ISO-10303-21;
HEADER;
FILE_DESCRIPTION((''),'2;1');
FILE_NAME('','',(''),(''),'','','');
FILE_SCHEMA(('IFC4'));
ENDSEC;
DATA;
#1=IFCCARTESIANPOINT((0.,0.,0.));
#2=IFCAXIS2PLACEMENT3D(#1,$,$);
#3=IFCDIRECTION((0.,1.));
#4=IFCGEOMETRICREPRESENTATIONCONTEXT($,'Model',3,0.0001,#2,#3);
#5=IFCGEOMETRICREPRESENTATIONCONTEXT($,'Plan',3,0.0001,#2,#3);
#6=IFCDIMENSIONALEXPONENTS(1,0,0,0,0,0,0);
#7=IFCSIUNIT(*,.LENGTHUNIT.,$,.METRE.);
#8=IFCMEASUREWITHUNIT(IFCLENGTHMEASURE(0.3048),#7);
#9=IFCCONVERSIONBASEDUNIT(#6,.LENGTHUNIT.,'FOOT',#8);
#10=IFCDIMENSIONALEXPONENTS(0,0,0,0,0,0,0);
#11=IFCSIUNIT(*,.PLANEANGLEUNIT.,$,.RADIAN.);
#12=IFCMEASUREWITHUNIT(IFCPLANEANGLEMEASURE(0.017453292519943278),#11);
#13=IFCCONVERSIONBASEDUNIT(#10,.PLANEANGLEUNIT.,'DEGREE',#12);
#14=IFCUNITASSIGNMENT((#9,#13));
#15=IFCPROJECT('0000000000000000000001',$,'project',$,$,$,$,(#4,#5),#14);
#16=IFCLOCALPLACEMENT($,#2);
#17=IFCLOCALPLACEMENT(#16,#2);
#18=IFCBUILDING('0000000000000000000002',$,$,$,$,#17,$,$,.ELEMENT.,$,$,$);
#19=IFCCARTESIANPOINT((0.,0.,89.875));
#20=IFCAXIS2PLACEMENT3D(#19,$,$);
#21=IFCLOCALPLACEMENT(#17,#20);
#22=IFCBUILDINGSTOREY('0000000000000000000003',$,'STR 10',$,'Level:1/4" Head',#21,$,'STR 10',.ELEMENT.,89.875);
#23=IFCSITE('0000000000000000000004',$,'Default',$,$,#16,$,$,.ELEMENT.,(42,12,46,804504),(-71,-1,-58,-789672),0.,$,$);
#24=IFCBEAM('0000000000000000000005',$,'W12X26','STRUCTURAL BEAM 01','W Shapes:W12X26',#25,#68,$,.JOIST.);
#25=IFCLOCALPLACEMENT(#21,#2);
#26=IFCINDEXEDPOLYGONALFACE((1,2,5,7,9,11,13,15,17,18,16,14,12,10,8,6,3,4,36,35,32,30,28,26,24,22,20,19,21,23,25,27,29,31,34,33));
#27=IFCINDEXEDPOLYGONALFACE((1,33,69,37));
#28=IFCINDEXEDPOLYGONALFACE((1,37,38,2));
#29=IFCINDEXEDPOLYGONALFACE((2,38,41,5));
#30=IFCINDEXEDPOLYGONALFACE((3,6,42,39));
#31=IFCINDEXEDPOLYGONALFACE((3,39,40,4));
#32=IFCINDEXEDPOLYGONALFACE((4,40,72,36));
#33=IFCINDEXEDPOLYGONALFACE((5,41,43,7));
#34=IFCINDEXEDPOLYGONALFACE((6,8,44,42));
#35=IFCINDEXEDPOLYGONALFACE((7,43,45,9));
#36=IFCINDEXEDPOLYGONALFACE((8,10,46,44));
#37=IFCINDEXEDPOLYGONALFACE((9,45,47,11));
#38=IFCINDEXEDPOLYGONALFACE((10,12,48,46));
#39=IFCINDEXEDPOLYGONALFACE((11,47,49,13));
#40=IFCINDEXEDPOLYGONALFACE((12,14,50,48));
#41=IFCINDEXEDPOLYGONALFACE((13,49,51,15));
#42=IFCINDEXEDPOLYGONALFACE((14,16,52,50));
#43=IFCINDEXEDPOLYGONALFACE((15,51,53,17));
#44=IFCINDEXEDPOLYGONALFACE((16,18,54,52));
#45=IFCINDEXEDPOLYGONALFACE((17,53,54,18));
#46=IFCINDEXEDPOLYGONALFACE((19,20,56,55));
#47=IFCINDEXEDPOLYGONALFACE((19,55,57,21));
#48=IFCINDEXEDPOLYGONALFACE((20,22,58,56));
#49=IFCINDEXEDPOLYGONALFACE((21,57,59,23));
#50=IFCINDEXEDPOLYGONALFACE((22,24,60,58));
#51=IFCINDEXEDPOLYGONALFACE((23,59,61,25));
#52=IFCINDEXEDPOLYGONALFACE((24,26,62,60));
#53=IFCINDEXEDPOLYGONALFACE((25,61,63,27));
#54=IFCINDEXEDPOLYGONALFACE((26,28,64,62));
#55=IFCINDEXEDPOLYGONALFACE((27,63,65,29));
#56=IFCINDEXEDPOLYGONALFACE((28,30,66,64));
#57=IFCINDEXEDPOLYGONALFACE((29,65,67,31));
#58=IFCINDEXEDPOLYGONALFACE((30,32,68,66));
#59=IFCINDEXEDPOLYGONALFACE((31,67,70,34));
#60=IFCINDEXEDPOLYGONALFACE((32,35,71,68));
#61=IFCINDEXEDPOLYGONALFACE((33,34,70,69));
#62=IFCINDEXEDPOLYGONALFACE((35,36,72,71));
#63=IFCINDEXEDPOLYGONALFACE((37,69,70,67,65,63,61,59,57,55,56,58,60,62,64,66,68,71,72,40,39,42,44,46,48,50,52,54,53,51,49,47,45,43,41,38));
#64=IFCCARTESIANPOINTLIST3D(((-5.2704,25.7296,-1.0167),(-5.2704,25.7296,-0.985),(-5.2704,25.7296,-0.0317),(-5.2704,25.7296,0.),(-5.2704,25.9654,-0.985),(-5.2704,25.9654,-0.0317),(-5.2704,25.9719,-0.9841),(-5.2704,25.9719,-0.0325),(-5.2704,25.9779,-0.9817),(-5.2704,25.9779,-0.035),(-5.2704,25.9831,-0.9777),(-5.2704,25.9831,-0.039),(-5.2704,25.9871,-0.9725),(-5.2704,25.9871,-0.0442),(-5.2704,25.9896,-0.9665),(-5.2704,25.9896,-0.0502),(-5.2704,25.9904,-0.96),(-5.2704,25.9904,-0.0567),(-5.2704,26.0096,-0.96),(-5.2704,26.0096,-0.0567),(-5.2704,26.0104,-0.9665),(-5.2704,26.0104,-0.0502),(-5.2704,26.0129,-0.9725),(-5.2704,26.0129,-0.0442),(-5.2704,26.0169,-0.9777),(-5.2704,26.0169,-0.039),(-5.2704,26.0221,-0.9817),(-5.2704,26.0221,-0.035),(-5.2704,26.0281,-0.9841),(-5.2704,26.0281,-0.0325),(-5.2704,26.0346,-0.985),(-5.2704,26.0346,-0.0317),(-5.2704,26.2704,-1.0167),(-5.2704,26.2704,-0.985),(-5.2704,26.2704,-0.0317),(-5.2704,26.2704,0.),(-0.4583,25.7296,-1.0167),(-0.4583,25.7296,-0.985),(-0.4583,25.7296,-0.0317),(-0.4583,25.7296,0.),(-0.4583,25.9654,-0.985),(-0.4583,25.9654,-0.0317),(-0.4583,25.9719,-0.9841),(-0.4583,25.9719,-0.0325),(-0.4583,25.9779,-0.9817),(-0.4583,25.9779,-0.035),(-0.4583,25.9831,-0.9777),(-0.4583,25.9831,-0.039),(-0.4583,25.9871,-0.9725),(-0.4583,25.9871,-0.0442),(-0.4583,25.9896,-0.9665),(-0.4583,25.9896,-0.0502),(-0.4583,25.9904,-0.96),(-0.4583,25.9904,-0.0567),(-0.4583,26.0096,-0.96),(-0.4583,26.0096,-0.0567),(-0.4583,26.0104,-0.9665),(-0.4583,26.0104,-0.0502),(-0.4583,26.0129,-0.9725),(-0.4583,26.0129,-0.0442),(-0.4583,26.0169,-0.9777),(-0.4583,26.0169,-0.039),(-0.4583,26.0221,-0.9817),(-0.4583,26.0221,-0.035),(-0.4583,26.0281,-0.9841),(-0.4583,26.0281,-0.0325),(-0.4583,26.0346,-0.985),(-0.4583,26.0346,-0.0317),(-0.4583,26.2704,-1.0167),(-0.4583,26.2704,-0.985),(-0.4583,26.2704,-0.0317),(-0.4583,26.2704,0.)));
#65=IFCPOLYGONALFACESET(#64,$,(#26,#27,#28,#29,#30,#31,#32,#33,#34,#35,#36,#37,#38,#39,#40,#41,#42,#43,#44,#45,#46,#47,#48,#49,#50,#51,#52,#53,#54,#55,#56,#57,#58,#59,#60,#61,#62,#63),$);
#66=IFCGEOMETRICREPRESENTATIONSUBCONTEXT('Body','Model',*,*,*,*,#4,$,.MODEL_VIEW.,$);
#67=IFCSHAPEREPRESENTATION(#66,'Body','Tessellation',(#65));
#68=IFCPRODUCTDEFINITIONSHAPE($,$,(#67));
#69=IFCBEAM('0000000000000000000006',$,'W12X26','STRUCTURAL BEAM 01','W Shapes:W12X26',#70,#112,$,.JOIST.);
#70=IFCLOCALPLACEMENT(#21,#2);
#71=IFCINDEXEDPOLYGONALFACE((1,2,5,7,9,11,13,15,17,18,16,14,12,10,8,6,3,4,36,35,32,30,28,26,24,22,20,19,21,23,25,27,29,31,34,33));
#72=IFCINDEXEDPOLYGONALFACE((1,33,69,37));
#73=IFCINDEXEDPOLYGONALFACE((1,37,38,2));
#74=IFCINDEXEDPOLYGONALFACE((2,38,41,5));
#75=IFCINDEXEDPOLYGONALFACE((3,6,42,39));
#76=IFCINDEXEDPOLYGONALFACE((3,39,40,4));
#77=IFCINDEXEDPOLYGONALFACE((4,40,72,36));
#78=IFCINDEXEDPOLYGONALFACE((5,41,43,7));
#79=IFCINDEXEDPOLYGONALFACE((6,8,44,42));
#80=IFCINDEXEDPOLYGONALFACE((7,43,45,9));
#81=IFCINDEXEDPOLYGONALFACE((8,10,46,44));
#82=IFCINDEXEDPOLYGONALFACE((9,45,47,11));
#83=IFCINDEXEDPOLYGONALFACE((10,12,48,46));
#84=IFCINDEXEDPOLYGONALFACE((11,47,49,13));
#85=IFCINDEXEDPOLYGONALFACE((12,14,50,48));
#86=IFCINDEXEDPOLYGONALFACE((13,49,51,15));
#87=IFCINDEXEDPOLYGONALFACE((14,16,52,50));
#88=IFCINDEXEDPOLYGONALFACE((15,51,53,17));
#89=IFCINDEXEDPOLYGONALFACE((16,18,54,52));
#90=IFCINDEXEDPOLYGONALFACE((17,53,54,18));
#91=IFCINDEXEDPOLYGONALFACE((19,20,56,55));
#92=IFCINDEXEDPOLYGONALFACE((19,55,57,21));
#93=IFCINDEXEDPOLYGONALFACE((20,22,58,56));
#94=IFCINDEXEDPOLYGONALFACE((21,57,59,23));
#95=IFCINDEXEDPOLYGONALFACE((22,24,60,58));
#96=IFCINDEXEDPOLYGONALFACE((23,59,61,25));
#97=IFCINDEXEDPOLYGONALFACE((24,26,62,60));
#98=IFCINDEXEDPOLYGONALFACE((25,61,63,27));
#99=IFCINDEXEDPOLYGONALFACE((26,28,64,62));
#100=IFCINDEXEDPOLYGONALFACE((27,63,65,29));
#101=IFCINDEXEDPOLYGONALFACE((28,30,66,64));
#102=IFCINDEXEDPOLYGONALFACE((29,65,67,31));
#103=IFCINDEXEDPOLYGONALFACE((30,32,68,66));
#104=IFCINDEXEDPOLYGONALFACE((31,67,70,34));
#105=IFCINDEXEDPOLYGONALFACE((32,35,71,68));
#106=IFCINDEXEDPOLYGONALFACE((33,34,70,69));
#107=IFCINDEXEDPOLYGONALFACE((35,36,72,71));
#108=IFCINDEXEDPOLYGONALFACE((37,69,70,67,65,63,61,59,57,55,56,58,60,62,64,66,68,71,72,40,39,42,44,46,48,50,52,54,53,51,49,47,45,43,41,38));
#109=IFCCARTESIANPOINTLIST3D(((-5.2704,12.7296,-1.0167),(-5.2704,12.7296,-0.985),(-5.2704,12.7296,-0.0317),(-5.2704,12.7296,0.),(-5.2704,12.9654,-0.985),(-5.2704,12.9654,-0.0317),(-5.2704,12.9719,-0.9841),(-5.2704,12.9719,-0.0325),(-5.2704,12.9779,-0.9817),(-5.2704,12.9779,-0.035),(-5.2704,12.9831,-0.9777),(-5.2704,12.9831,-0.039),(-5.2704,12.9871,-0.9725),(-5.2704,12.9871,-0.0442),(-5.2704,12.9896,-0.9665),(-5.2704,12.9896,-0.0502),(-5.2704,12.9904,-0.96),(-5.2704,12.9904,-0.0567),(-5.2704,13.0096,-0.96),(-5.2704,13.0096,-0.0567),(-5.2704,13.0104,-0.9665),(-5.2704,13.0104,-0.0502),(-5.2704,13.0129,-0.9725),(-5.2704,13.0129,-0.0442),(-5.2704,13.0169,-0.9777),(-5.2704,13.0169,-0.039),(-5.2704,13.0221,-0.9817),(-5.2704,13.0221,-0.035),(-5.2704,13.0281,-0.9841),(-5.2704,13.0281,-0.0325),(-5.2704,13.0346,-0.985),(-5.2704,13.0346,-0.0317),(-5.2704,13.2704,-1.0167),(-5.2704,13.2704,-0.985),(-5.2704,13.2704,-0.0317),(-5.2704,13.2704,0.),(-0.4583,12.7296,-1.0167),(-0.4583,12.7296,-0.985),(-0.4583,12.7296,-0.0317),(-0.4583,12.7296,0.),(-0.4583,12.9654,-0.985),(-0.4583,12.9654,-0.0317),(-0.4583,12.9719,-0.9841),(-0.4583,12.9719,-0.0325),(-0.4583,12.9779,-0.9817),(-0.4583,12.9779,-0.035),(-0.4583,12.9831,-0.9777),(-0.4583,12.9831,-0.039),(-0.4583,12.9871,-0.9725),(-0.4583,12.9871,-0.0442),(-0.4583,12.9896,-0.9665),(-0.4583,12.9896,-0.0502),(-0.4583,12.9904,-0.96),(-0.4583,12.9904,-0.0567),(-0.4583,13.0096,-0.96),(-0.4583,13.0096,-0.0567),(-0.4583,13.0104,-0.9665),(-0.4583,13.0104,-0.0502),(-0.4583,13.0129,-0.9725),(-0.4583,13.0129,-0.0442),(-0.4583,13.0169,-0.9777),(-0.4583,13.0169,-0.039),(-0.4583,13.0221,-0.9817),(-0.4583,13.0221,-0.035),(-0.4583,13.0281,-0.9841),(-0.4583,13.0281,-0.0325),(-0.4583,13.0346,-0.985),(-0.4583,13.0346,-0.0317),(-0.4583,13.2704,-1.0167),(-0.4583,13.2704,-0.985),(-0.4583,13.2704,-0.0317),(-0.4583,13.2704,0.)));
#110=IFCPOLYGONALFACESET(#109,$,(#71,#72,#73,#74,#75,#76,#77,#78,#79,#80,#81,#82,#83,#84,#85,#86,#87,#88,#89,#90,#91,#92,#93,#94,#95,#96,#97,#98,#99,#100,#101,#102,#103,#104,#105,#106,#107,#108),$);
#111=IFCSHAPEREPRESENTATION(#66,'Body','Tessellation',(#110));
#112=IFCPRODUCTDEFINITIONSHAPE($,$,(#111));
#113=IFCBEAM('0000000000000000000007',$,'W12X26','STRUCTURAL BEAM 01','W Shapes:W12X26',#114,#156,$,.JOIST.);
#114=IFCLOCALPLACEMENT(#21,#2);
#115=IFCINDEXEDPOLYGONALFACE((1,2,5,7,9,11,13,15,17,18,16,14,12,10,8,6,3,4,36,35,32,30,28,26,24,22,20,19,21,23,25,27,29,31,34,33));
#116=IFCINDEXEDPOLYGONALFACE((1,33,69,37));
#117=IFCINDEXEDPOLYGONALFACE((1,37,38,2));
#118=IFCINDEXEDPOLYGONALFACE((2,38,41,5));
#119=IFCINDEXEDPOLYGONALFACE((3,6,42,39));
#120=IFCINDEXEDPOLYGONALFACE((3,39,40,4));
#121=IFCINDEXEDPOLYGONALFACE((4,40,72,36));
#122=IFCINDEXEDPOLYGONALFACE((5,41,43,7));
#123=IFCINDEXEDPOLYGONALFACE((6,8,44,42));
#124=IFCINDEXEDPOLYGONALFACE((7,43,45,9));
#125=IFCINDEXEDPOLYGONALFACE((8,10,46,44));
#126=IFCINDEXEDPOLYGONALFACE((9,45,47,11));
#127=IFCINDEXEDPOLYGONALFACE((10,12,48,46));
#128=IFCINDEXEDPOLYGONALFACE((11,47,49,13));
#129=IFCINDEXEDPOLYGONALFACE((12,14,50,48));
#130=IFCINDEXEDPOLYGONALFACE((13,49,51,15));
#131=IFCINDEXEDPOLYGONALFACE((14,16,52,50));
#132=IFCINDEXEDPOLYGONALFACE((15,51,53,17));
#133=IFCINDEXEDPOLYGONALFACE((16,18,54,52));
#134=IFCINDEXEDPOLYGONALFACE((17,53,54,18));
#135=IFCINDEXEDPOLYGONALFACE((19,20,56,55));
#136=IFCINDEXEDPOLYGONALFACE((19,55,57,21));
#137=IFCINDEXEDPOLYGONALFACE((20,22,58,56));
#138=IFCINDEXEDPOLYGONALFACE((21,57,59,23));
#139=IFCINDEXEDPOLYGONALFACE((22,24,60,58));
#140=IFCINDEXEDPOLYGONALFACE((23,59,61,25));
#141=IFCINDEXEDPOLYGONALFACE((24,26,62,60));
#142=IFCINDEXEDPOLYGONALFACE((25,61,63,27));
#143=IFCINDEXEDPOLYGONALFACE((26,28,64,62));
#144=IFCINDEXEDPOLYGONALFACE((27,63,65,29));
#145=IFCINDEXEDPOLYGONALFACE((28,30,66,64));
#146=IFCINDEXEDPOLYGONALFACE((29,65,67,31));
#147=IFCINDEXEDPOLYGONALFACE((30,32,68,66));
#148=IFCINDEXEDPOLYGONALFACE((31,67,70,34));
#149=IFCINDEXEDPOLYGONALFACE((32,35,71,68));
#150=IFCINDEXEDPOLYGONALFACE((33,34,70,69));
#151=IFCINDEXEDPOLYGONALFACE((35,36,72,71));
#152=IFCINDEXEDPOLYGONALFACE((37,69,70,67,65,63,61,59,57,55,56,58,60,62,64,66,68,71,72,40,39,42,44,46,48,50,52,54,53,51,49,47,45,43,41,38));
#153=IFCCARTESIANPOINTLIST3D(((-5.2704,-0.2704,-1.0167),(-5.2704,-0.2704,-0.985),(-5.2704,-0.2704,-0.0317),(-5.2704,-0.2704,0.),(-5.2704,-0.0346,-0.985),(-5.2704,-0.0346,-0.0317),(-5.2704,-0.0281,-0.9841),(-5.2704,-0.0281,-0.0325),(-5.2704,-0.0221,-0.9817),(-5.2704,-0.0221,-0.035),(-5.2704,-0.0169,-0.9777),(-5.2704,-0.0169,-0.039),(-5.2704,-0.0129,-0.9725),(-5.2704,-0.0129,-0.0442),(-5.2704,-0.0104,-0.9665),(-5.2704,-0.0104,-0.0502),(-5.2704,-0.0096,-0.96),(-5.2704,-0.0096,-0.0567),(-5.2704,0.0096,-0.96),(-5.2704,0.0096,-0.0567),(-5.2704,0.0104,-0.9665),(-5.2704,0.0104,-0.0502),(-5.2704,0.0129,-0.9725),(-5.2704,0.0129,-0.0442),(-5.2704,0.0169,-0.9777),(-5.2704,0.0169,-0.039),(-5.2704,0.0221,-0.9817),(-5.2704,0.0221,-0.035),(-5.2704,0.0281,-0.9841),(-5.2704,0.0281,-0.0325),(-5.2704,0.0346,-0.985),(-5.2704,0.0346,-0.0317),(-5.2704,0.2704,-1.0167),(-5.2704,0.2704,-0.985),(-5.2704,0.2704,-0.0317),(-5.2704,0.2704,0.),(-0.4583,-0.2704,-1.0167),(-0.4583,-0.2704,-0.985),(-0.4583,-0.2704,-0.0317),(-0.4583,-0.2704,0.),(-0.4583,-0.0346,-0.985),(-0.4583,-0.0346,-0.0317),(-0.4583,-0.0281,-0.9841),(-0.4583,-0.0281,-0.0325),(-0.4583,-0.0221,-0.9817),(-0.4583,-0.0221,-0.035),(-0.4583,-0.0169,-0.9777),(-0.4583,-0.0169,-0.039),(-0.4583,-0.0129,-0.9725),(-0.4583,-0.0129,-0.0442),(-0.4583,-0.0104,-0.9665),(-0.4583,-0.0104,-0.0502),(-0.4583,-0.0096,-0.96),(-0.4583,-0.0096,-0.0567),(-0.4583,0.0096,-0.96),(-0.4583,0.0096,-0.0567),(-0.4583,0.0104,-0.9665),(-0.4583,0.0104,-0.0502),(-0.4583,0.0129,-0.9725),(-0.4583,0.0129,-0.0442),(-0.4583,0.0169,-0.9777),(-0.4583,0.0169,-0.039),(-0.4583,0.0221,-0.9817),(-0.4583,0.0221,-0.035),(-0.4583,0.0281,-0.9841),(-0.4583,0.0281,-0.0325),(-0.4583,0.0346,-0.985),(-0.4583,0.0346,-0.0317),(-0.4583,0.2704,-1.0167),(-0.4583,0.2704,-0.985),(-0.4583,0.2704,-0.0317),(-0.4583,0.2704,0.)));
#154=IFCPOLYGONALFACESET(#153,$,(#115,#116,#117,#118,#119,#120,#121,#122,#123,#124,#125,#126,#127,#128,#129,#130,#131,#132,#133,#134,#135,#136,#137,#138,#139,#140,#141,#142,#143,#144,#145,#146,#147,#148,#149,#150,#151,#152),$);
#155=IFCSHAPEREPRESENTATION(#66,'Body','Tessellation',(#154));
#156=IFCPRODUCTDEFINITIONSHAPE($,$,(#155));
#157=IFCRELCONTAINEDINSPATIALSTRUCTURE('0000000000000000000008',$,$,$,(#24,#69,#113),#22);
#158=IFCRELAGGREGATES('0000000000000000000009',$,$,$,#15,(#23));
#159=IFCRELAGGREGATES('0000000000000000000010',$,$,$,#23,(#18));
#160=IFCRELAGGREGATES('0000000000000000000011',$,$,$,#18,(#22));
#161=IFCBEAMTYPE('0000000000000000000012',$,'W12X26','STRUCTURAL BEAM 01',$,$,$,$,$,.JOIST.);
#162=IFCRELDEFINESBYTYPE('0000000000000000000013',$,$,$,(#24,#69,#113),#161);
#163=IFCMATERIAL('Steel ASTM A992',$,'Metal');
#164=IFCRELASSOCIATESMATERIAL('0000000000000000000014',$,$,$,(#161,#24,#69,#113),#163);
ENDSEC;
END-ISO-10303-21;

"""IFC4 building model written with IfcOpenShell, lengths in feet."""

from ifc_helpers import new_model, entity, si_unit, converted_unit, direction, frame, origin, place, context, subcontext, project, spatial, line, arc, indexed_curve, outline, extrude, source, transform, mapped, material, type_object, type_shapes, element, save


model = new_model("IFC4")

# Units and contexts
model_context = context("Model", 3, precision=0.0001, world=origin(), true_north=direction((0.0, 1.0)))
plan_context = context("Plan", 3, precision=0.0001, world=origin(), true_north=direction((0.0, 1.0)))
body_context = subcontext(model_context, "Body", "Model", "MODEL_VIEW")
ifc_project = project(units=[converted_unit("LENGTHUNIT", "FOOT", entity("IfcLengthMeasure", 0.3048), si_unit("LENGTHUNIT", "METRE"), dimensions=[1, 0, 0, 0, 0, 0, 0]), converted_unit("PLANEANGLEUNIT", "DEGREE", entity("IfcPlaneAngleMeasure", 0.017453292519943278), si_unit("PLANEANGLEUNIT", "RADIAN"), dimensions=[0, 0, 0, 0, 0, 0, 0])], contexts=[model_context, plan_context])

# Site, building, storey
site_placement = place(None, origin())
site = spatial("IfcSite", under=ifc_project, at=site_placement, Name="Default", CompositionType="ELEMENT", RefLatitude=(42, 12, 46, 804504), RefLongitude=(-71, -1, -58, -789672), RefElevation=0.0)
building_placement = place(site_placement, origin())
building = spatial("IfcBuilding", under=site, at=building_placement, CompositionType="ELEMENT")
storey_placement = place(building_placement, frame((0.0, 0.0, 89.875)))
storey = spatial("IfcBuildingStorey", under=building, at=storey_placement, Name="STR 10", ObjectType="Level:1/4\" Head", LongName="STR 10", CompositionType="ELEMENT", Elevation=89.875)

# Beams
ifc_material = material(Name="Steel ASTM A992", Category="Metal")
beam_type_1 = type_object("IfcBeamType", Name="W12X26", Description="STRUCTURAL BEAM 01", PredefinedType="JOIST", material=ifc_material)
shared_shape_1 = source(origin(), body_context, "Body", "SweptSolid", [
    extrude(outline(indexed_curve([(0.4767, -0.2704), (0.5083, -0.2704), (0.5083, 0.2704), (0.4767, 0.2704), (0.4767, 0.0346), (0.4693, 0.0169), (0.4517, 0.0096), (-0.4517, 0.0096), (-0.4693, 0.0169), (-0.4767, 0.0346), (-0.4767, 0.2704), (-0.5083, 0.2704), (-0.5083, -0.2704), (-0.4767, -0.2704), (-0.4767, -0.0346), (-0.4693, -0.0169), (-0.4517, -0.0096), (0.4517, -0.0096), (0.4693, -0.0169), (0.4767, -0.0346)], segments=[line(1, 2, 3, 4, 5), arc(5, 6, 7), line(7, 8), arc(8, 9, 10), line(10, 11, 12, 13, 14, 15), arc(15, 16, 17), line(17, 18), arc(18, 19, 20), line(20, 1)], self_intersect=False)), frame((-2.0417, 0.0, 0.0), z_axis=(1.0, 0.0, 0.0), x_axis=(0.0, 0.0, -1.0)), (0.0, 0.0, 1.0), 4.8121),
])
type_shapes(beam_type_1, [shared_shape_1])
for number, where, z_axis, x_axis, name in (
    (1, (-2.5, 26.0, -0.5083), (0.0, 0.0, 1.0), (-1.0, 0.0, 0.0), "W12X26"),
    (2, (-2.5, 13.0, -0.5083), (0.0, 0.0, 1.0), (-1.0, 0.0, 0.0), "W12X26"),
    (3, (-2.5, 0.0, -0.5083), (0.0, 0.0, 1.0), (-1.0, 0.0, 0.0), "W12X26"),
):
    element("IfcBeam", number, at=place(storey_placement, frame(where, z_axis=z_axis, x_axis=x_axis)), inside=storey, type_object=beam_type_1, material=ifc_material, Name=name, Description="STRUCTURAL BEAM 01", ObjectType="W Shapes:W12X26", PredefinedType="JOIST", context=body_context, shape_type="MappedRepresentation", body=[
        mapped(shared_shape_1, transform((0.0, 0.0, 0.0), scale=1.0)),
    ])

save(model, "model.ifc")
